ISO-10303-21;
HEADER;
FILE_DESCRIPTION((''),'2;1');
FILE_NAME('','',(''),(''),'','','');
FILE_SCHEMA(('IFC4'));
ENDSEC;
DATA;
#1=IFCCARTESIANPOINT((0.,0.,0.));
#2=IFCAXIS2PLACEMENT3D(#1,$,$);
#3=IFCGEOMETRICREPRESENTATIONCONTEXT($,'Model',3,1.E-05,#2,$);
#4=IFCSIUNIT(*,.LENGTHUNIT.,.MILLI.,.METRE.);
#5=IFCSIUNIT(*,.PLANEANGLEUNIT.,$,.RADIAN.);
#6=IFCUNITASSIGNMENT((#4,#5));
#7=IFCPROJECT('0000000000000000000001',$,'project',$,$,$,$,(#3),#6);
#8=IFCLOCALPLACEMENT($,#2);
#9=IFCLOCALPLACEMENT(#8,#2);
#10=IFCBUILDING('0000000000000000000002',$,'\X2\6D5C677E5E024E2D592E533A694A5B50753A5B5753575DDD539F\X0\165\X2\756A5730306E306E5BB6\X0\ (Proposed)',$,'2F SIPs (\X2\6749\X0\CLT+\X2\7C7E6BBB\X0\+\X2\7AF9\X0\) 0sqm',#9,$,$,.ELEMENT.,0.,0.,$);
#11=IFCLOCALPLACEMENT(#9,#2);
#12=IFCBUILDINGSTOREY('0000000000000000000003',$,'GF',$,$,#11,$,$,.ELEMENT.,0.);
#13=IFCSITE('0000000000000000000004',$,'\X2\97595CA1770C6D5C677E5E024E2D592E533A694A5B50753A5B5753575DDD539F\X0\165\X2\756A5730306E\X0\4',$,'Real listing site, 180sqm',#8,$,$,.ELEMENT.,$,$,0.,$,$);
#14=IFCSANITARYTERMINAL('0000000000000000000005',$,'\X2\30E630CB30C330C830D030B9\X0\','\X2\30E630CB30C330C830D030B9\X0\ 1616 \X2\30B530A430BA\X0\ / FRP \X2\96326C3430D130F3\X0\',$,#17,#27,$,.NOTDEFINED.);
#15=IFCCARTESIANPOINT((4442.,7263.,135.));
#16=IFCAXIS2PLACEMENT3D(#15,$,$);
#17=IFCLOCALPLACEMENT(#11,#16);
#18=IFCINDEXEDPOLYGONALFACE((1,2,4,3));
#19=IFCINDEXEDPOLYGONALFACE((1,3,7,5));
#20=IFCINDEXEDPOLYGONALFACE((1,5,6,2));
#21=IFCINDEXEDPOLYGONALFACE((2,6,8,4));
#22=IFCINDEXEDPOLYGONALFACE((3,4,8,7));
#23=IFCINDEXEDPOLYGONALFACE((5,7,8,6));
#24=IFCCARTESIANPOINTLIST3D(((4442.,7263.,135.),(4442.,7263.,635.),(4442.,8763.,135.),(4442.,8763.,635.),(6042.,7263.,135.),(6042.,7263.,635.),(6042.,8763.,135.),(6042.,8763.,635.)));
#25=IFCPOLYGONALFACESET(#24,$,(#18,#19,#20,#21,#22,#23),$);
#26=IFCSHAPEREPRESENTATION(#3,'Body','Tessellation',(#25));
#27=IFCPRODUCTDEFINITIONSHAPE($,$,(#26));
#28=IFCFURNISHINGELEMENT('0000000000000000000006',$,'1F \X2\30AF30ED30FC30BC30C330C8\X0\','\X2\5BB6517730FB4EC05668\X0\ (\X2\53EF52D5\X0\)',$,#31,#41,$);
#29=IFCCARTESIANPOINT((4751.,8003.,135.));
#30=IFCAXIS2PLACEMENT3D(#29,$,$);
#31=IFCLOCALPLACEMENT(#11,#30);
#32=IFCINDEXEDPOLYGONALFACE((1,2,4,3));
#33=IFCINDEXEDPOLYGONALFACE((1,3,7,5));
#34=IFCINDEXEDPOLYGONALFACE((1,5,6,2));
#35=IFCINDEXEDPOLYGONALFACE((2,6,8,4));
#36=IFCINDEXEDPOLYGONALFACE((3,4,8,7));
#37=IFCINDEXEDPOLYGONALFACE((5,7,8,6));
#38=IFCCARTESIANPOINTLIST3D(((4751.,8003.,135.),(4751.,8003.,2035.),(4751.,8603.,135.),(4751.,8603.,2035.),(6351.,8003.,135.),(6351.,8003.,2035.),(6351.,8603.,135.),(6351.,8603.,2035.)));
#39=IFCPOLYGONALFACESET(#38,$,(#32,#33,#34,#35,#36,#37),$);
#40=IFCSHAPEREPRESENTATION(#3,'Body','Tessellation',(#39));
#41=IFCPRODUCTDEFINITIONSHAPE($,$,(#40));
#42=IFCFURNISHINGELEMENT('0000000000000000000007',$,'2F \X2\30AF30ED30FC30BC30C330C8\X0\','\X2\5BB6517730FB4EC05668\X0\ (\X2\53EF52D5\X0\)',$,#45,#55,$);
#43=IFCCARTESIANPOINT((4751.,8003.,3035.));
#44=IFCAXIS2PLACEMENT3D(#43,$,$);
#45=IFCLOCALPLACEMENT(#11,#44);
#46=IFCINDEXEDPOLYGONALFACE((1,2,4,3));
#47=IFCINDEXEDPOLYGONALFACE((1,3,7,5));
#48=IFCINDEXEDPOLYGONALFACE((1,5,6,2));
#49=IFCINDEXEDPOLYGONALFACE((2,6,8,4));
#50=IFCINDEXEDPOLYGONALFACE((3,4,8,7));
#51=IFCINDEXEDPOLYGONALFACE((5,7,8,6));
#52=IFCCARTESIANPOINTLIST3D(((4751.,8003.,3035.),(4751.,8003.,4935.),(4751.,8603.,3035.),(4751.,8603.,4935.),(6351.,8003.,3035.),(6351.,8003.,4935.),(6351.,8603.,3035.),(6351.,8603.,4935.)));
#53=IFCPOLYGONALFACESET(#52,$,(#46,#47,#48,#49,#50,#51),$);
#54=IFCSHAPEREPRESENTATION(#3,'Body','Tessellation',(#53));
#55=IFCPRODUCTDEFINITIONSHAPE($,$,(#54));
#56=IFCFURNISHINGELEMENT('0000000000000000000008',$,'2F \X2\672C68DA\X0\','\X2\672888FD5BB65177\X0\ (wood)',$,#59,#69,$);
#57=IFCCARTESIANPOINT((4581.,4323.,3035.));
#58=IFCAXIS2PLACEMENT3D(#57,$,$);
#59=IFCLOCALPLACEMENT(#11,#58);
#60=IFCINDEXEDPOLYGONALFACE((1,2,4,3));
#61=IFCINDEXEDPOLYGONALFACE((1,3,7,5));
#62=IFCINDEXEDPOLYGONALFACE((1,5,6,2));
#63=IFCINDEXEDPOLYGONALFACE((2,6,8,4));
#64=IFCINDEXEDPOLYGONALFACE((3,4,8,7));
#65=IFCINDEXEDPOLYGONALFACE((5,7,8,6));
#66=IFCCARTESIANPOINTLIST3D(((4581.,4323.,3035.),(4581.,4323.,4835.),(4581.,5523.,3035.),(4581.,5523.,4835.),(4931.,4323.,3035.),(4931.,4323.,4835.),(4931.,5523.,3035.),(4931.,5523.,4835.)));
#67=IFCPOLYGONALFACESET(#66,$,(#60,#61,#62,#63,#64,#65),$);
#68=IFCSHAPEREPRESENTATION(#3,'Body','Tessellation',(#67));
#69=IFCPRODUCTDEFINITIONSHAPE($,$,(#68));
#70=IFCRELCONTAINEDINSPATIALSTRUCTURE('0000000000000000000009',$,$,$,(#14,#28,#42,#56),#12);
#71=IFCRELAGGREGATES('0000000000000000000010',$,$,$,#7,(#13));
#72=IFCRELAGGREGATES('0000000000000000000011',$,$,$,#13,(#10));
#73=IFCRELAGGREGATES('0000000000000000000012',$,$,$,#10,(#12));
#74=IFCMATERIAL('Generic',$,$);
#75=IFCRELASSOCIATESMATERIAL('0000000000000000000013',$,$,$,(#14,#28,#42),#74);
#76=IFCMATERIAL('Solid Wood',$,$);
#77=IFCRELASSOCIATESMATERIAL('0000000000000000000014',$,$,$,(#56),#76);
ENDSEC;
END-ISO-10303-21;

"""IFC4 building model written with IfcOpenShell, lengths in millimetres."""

from ifc_helpers import new_model, si_unit, frame, frame_2d, origin, place, context, project, spatial, rectangle, extrude, material, element, save


model = new_model("IFC4")

# Units and contexts
model_context = context("Model", 3, precision=1e-05, world=origin())
ifc_project = project(units=[si_unit("LENGTHUNIT", "METRE", prefix="MILLI"), si_unit("PLANEANGLEUNIT", "RADIAN")], contexts=[model_context])

# Site, building, storey
site_placement = place(None, origin())
site = spatial("IfcSite", under=ifc_project, at=site_placement, Name="静岡県浜松市中央区楊子町字南川原165番地の4", ObjectType="Real listing site, 180sqm", CompositionType="ELEMENT", RefElevation=0.0)
building_placement = place(site_placement, origin())
building = spatial("IfcBuilding", under=site, at=building_placement, Name="浜松市中央区楊子町字南川原165番地のの家 (Proposed)", ObjectType="2F SIPs (杉CLT+籾殻+竹) 0sqm", CompositionType="ELEMENT", ElevationOfRefHeight=0.0, ElevationOfTerrain=0.0)
storey_placement = place(building_placement, origin())
storey = spatial("IfcBuildingStorey", under=building, at=storey_placement, Name="GF", CompositionType="ELEMENT", Elevation=0.0)

# Shared definitions
ifc_material_1 = material(Name="Solid Wood")

# Shared definitions
ifc_material_2 = material(Name="Generic")

# Sanitary terminal
sanitary_terminal_placement = place(storey_placement, frame((4442.0, 7263.0, 135.0)))
element("IfcSanitaryTerminal", 1, at=sanitary_terminal_placement, inside=storey, material=ifc_material_2, Name="ユニットバス", Description="ユニットバス 1616 サイズ / FRP 防水パン", PredefinedType="NOTDEFINED", context=model_context, shape_type="SweptSolid", body=[
    extrude(rectangle(XDim=1600.0, YDim=1500.0, at=frame_2d((800.0, 750.0))), frame((4442.0, 7263.0, 135.0)), (0.0, 0.0, 1.0), 500.0),
])

# Furnishing elements
furnishing_1_placement = place(storey_placement, frame((4751.0, 8003.0, 135.0)))
element("IfcFurnishingElement", 2, at=furnishing_1_placement, inside=storey, material=ifc_material_2, Name="1F クローゼット", Description="家具・什器 (可動)", context=model_context, shape_type="SweptSolid", body=[
    extrude(rectangle(XDim=1600.0, YDim=600.0, at=frame_2d((800.0, 300.0))), frame((4751.0, 8003.0, 135.0)), (0.0, 0.0, 1.0), 1900.0),
])
furnishing_2_placement = place(storey_placement, frame((4751.0, 8003.0, 3035.0)))
element("IfcFurnishingElement", 3, at=furnishing_2_placement, inside=storey, material=ifc_material_2, Name="2F クローゼット", Description="家具・什器 (可動)", context=model_context, shape_type="SweptSolid", body=[
    extrude(rectangle(XDim=1600.0, YDim=600.0, at=frame_2d((800.0, 300.0))), frame((4751.0, 8003.0, 3035.0)), (0.0, 0.0, 1.0), 1900.0),
])
furnishing_3_placement = place(storey_placement, frame((4581.0, 4323.0, 3035.0)))
element("IfcFurnishingElement", 4, at=furnishing_3_placement, inside=storey, material=ifc_material_1, Name="2F 本棚", Description="木製家具 (wood)", context=model_context, shape_type="SweptSolid", body=[
    extrude(rectangle(XDim=350.0, YDim=1200.0, at=frame_2d((175.0, 600.0))), frame((4581.0, 4323.0, 3035.0)), (0.0, 0.0, 1.0), 1800.0),
])

save(model, "model.ifc")
